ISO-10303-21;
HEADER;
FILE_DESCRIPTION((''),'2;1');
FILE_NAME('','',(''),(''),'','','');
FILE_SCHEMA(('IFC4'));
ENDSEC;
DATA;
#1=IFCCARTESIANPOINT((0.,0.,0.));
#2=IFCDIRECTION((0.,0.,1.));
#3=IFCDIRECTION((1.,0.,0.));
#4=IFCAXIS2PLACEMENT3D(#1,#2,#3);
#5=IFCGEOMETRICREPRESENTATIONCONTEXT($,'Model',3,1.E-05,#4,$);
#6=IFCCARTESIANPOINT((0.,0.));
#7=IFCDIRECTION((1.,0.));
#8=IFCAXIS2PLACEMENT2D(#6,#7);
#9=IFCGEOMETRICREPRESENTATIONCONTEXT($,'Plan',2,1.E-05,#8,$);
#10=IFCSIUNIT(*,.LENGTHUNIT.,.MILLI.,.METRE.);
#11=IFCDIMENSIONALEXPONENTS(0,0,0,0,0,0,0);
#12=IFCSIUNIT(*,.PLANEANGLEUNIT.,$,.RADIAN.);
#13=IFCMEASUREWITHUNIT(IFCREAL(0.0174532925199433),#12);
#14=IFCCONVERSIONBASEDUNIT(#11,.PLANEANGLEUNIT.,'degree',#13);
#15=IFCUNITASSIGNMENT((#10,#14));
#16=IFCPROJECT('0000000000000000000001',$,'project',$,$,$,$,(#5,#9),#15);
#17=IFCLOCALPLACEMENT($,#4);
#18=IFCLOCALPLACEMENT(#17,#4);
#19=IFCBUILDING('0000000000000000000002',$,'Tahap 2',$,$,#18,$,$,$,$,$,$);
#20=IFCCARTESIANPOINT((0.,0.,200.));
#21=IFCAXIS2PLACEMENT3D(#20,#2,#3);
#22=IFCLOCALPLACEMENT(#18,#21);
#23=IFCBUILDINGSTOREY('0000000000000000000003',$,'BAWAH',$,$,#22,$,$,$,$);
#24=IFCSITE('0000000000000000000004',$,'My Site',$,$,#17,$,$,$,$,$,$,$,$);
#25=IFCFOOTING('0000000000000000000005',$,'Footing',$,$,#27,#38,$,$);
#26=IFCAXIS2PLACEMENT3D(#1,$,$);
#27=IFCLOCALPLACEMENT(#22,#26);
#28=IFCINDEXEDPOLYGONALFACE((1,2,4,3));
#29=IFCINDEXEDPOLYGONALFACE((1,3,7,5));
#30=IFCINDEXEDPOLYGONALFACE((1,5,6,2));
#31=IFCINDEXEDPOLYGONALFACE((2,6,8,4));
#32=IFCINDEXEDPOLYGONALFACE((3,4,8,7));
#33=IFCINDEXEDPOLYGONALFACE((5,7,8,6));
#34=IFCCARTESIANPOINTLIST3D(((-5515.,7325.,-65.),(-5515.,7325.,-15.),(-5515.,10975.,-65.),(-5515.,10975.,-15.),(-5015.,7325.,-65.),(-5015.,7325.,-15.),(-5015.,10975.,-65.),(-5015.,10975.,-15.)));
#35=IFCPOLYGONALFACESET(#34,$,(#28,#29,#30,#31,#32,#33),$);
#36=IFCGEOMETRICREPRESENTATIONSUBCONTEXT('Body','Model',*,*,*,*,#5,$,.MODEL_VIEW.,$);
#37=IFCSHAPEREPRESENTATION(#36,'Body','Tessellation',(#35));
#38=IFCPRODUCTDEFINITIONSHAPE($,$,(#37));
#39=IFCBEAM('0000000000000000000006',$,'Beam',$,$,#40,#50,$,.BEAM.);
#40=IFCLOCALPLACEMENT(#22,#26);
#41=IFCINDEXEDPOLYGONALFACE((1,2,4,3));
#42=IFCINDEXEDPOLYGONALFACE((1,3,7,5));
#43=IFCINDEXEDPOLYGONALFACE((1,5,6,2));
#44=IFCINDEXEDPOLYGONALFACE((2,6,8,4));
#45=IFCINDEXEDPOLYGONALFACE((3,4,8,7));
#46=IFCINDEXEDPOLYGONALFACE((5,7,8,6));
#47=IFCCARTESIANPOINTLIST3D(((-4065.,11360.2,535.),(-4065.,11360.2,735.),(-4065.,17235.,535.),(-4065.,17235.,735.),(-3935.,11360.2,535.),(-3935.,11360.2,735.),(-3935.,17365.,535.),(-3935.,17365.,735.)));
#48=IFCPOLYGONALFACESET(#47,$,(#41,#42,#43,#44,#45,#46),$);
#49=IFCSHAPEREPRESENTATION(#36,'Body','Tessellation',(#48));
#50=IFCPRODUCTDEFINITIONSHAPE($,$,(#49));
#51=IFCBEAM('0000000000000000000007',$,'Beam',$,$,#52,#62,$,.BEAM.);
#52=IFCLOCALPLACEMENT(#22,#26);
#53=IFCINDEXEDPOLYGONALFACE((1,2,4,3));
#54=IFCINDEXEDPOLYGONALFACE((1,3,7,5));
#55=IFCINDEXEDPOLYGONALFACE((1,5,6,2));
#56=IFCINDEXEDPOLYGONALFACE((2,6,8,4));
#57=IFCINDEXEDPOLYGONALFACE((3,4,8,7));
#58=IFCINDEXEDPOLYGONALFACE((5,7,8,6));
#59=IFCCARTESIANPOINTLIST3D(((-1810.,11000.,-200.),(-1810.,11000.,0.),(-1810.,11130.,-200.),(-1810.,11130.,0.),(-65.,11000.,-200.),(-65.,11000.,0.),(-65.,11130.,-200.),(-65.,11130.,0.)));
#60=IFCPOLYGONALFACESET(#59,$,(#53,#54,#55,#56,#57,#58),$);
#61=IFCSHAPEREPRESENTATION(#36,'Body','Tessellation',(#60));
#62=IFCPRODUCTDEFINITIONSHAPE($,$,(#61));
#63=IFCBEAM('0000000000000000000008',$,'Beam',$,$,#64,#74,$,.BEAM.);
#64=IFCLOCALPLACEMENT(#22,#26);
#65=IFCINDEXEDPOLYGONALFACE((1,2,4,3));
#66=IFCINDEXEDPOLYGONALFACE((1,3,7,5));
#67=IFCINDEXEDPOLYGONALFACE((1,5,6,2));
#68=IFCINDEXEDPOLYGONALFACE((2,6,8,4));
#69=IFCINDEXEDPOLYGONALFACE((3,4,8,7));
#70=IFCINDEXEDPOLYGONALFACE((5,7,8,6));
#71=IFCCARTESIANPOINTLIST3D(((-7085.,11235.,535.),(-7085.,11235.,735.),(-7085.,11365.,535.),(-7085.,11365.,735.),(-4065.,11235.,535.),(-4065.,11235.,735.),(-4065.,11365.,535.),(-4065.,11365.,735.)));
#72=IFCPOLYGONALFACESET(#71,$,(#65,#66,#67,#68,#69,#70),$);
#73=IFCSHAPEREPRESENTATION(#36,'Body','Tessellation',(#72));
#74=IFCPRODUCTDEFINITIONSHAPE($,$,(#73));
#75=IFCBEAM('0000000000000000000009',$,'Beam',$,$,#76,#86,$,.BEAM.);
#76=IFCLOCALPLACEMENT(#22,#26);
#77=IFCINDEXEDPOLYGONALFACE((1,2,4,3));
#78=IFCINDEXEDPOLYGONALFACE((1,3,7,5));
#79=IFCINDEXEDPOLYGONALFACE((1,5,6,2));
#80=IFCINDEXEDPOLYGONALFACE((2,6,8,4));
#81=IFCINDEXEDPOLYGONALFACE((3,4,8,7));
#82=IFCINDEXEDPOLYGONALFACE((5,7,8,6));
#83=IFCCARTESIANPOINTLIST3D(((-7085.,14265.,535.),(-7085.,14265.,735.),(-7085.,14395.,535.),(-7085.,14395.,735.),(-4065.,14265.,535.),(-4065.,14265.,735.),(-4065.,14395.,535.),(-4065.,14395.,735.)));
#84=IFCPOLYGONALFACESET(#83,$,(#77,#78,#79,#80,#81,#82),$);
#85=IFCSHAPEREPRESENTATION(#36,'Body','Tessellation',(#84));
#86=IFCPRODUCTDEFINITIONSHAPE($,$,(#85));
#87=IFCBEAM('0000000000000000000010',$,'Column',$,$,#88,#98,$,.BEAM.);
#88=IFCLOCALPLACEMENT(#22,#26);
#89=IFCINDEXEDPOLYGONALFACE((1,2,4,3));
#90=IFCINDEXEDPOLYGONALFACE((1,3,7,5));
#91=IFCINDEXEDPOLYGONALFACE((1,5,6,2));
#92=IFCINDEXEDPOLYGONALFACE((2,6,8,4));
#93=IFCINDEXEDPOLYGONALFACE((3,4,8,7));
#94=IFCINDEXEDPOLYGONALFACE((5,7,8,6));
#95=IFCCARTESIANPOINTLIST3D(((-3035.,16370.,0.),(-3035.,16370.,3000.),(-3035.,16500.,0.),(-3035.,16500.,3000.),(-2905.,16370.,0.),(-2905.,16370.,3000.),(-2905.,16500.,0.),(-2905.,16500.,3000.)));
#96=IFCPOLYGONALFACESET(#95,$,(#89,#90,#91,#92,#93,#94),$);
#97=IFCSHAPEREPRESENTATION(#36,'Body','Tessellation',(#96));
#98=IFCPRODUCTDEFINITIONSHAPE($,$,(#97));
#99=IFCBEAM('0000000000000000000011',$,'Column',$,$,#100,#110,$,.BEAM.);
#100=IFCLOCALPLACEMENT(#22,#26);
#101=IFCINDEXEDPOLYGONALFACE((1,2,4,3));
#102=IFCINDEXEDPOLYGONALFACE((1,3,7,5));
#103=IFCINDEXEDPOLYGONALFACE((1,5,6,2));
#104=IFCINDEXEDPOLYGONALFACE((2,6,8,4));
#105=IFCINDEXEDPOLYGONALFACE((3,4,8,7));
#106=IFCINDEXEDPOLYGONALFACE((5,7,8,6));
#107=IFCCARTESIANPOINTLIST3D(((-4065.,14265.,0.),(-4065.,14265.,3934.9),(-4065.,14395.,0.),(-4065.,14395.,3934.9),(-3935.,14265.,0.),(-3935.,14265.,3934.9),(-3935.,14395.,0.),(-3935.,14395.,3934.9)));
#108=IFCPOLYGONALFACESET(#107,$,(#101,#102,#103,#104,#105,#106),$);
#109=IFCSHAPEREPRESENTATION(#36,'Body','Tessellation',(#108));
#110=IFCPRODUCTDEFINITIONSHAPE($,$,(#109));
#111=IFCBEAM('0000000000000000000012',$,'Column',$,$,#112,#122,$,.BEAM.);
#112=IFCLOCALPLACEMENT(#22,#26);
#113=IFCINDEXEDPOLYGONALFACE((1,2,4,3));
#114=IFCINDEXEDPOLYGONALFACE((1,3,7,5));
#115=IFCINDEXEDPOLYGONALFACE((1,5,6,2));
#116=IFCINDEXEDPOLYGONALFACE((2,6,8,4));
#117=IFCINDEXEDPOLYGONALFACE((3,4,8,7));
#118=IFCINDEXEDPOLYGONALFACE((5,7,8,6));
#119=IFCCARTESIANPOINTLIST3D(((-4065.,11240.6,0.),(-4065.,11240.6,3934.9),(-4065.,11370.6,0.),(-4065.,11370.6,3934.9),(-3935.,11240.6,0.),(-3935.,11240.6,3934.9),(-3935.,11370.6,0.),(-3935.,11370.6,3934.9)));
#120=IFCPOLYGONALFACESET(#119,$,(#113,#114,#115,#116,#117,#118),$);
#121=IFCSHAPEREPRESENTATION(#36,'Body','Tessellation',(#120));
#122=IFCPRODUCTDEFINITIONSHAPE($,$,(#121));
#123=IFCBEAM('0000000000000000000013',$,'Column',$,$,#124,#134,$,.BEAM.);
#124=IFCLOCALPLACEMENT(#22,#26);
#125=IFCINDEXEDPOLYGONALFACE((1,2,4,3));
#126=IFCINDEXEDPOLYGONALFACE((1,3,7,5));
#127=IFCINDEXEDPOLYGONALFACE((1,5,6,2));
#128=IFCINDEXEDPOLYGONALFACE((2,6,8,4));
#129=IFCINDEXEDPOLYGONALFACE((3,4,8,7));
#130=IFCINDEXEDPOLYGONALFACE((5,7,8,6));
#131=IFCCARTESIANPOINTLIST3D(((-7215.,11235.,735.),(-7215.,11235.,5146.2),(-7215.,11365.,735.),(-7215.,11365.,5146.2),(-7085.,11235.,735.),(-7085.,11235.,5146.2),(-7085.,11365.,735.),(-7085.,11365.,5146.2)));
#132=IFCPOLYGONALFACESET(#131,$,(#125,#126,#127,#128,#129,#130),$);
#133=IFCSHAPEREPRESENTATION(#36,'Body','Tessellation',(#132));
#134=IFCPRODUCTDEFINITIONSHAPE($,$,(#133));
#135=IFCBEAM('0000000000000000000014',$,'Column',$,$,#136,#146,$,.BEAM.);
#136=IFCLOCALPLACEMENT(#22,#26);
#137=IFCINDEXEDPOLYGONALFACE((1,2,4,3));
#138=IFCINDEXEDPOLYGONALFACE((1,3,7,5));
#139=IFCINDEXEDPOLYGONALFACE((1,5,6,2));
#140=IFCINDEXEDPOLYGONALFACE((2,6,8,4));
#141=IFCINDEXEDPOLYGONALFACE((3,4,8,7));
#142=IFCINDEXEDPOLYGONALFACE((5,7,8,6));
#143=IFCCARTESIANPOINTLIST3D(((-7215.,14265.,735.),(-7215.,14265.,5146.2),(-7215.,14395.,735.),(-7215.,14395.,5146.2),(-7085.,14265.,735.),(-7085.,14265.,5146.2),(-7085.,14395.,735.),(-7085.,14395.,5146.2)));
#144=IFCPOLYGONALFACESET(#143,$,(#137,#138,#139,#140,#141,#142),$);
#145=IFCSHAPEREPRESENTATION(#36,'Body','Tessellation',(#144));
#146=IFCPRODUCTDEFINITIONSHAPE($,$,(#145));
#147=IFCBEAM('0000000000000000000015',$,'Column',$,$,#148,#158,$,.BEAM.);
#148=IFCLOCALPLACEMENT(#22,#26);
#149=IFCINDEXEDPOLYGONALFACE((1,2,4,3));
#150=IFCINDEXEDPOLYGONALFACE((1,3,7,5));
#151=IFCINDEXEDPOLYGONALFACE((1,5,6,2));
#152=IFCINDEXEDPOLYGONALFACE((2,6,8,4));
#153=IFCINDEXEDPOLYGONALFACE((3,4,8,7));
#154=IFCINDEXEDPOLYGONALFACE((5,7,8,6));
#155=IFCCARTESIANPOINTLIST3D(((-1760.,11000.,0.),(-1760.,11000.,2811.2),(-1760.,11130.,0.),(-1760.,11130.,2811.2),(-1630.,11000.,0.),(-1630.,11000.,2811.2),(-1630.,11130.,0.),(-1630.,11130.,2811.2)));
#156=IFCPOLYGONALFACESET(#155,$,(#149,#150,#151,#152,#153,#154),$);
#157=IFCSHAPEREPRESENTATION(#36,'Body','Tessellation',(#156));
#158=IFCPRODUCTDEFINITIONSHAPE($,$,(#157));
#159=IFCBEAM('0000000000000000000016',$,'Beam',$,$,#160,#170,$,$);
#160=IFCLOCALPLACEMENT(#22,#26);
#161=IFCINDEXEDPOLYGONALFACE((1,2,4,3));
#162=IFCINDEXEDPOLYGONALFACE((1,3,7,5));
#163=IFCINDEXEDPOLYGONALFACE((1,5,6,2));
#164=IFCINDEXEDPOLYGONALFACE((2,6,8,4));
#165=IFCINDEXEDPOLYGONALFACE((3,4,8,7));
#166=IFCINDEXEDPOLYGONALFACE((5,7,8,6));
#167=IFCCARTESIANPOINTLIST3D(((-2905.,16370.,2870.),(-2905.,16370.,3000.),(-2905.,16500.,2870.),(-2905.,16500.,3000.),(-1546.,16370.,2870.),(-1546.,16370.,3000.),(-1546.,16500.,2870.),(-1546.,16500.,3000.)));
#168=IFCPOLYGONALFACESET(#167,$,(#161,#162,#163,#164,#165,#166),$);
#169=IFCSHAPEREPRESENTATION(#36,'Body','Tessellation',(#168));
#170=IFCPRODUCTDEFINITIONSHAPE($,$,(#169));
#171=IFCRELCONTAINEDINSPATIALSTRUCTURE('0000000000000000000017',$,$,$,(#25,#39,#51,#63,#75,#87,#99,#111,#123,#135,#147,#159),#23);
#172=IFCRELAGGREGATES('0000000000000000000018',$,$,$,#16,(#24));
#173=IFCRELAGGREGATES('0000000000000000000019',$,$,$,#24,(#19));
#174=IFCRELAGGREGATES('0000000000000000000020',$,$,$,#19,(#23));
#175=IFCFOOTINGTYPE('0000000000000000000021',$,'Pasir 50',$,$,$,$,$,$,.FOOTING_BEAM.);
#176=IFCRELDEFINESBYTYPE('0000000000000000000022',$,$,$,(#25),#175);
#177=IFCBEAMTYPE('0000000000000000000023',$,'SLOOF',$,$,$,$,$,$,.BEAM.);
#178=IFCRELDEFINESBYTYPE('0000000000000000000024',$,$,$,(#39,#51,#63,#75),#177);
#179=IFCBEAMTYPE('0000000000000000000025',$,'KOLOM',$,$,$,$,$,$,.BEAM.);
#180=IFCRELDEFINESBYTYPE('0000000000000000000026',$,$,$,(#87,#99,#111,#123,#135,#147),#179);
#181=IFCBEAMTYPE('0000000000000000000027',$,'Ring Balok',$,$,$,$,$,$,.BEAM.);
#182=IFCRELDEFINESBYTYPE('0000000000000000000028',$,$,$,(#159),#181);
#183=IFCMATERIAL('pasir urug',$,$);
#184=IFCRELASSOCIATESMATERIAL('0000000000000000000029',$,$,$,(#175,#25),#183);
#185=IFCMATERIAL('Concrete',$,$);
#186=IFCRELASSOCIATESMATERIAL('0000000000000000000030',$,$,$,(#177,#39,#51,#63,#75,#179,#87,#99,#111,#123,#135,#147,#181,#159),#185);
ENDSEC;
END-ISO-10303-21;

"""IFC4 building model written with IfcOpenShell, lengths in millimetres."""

from ifc_helpers import new_model, entity, si_unit, converted_unit, frame, origin_with_axes, origin_2d_with_axis, place, context, subcontext, project, spatial, indexed_curve, rectangle, outline, extrude, clip, halfspace, material, material_profile, profile_set, profile_usage, type_object, element, save


model = new_model("IFC4")

# Units and contexts
model_context = context("Model", 3, precision=1e-05, world=origin_with_axes())
plan_context = context("Plan", 2, precision=1e-05, world=origin_2d_with_axis())
body_context = subcontext(model_context, "Body", "Model", "MODEL_VIEW")
ifc_project = project(units=[si_unit("LENGTHUNIT", "METRE", prefix="MILLI"), converted_unit("PLANEANGLEUNIT", "degree", entity("IfcReal", 0.0174532925199433), si_unit("PLANEANGLEUNIT", "RADIAN"), dimensions=[0, 0, 0, 0, 0, 0, 0])], contexts=[model_context, plan_context])

# Site, building, storey
site_placement = place(None, origin_with_axes())
site = spatial("IfcSite", under=ifc_project, at=site_placement, Name="My Site")
building_placement = place(site_placement, origin_with_axes())
building = spatial("IfcBuilding", under=site, at=building_placement, Name="Tahap 2")
storey_placement = place(building_placement, frame((0.0, 0.0, 200.0), z_axis=(0.0, 0.0, 1.0), x_axis=(1.0, 0.0, 0.0)))
storey = spatial("IfcBuildingStorey", under=building, at=storey_placement, Name="BAWAH")

# Footing
ifc_material_1 = material(Name="pasir urug")
ifc_material_profile_1 = material_profile(ifc_material_1, rectangle(XDim=500.0, YDim=50.0, kind="CURVE"))
ifc_profile_set_1 = profile_set([ifc_material_profile_1])
ifc_profile_usage_1 = profile_usage(ifc_profile_set_1, cardinal=9)
footing_type = type_object("IfcFootingType", Name="Pasir 50", PredefinedType="FOOTING_BEAM", material=ifc_profile_set_1)
footing_placement = place(storey_placement, frame((-5515.0, 10975.0, -15.0), z_axis=(0.0, -1.0, 0.0), x_axis=(1.0, 0.0, 0.0)))
element("IfcFooting", 1, at=footing_placement, inside=storey, type_object=footing_type, material=ifc_profile_usage_1, Name="Footing", context=body_context, shape_type="SweptSolid", body=[
    extrude(rectangle(XDim=500.0, YDim=50.0, kind="CURVE"), frame((250.0, -25.0, 0.0), z_axis=(0.0, 0.0, 1.0), x_axis=(1.0, 0.0, 0.0)), (0.0, 0.0, 1.0), 3650.0),
])

# Beams
ifc_material_2 = material(Name="Concrete")
ifc_material_profile_2 = material_profile(ifc_material_2, outline(indexed_curve([(-65.0, 100.0), (65.0, 100.0), (65.0, -100.0), (-65.0, -100.0), (-65.0, 100.0)])))
ifc_profile_set_2 = profile_set([ifc_material_profile_2])
ifc_profile_usage_2 = profile_usage(ifc_profile_set_2, cardinal=3)
beam_type_1 = type_object("IfcBeamType", Name="SLOOF", PredefinedType="BEAM", material=ifc_profile_set_2)
beam_1_placement = place(storey_placement, frame((-3935.0, 11360.2, 535.0), z_axis=(0.0, 1.0, 0.0), x_axis=(-1.0, 0.0, 0.0)))
element("IfcBeam", 2, at=beam_1_placement, inside=storey, type_object=beam_type_1, material=ifc_profile_usage_2, Name="Beam", PredefinedType="BEAM", context=body_context, shape_type="Clipping", body=[
    clip(extrude(outline(indexed_curve([(-65.0, 100.0), (65.0, 100.0), (65.0, -100.0), (-65.0, -100.0), (-65.0, 100.0)])), frame((65.0, 100.0, 0.0), z_axis=(0.0, 0.0, 1.0), x_axis=(1.0, 0.0, 0.0)), (0.0, 0.0, 1.0), 6004.8), halfspace(frame((0.0, -735.0, 6004.8), z_axis=(0.707111, 0.0, 0.707103), x_axis=(0.0, -1.0, 0.0)), False)),
])
ifc_profile_usage_3 = profile_usage(ifc_profile_set_2, cardinal=2)
beam_2_placement = place(storey_placement, frame((-1810.0, 11065.0, -200.0), z_axis=(1.0, 0.0, 0.0), x_axis=(0.0, 1.0, 0.0)))
element("IfcBeam", 3, at=beam_2_placement, inside=storey, type_object=beam_type_1, material=ifc_profile_usage_3, Name="Beam", PredefinedType="BEAM", context=body_context, shape_type="SweptSolid", body=[
    extrude(outline(indexed_curve([(-65.0, 100.0), (65.0, 100.0), (65.0, -100.0), (-65.0, -100.0), (-65.0, 100.0)])), frame((0.0, 100.0, 0.0), z_axis=(0.0, 0.0, 1.0), x_axis=(1.0, 0.0, 0.0)), (0.0, 0.0, 1.0), 1745.0),
])
ifc_profile_usage_4 = profile_usage(ifc_profile_set_2, cardinal=2)
beam_3_placement = place(storey_placement, frame((-7085.0, 11300.0, 535.0), z_axis=(1.0, 0.0, 0.0), x_axis=(0.0, 1.0, 0.0)))
element("IfcBeam", 4, at=beam_3_placement, inside=storey, type_object=beam_type_1, material=ifc_profile_usage_4, Name="Beam", PredefinedType="BEAM", context=body_context, shape_type="SweptSolid", body=[
    extrude(outline(indexed_curve([(-65.0, 100.0), (65.0, 100.0), (65.0, -100.0), (-65.0, -100.0), (-65.0, 100.0)])), frame((0.0, 100.0, 0.0), z_axis=(0.0, 0.0, 1.0), x_axis=(1.0, 0.0, 0.0)), (0.0, 0.0, 1.0), 3020.0),
])
ifc_profile_usage_5 = profile_usage(ifc_profile_set_2, cardinal=2)
beam_4_placement = place(storey_placement, frame((-7085.0, 14330.0, 535.0), z_axis=(1.0, 0.0, 0.0), x_axis=(0.0, 1.0, 0.0)))
element("IfcBeam", 5, at=beam_4_placement, inside=storey, type_object=beam_type_1, material=ifc_profile_usage_5, Name="Beam", PredefinedType="BEAM", context=body_context, shape_type="SweptSolid", body=[
    extrude(outline(indexed_curve([(-65.0, 100.0), (65.0, 100.0), (65.0, -100.0), (-65.0, -100.0), (-65.0, 100.0)])), frame((0.0, 100.0, 0.0), z_axis=(0.0, 0.0, 1.0), x_axis=(1.0, 0.0, 0.0)), (0.0, 0.0, 1.0), 3020.0),
])
ifc_material_profile_3 = material_profile(ifc_material_2, rectangle(XDim=130.0, YDim=130.0, kind="CURVE"))
ifc_profile_set_3 = profile_set([ifc_material_profile_3])
ifc_profile_usage_6 = profile_usage(ifc_profile_set_3, cardinal=2)
beam_type_2 = type_object("IfcBeamType", Name="KOLOM", PredefinedType="BEAM", material=ifc_profile_set_3)
beam_5_placement = place(storey_placement, frame((-2970.0, 16370.0, 0.0), z_axis=(0.0, 0.0, 1.0), x_axis=(1.0, 0.0, 0.0)))
element("IfcBeam", 6, at=beam_5_placement, inside=storey, type_object=beam_type_2, material=ifc_profile_usage_6, Name="Column", PredefinedType="BEAM", context=body_context, shape_type="SweptSolid", body=[
    extrude(rectangle(XDim=130.0, YDim=130.0, kind="CURVE"), frame((0.0, 65.0, 0.0), z_axis=(0.0, 0.0, 1.0), x_axis=(1.0, 0.0, 0.0)), (0.0, 0.0, 1.0), 3000.0),
])
ifc_profile_usage_7 = profile_usage(ifc_profile_set_3, cardinal=5)
beam_6_placement = place(storey_placement, frame((-4000.0, 14330.0, 0.0), z_axis=(0.0, 0.0, 1.0), x_axis=(1.0, 0.0, 0.0)))
element("IfcBeam", 7, at=beam_6_placement, inside=storey, type_object=beam_type_2, material=ifc_profile_usage_7, Name="Column", PredefinedType="BEAM", context=body_context, shape_type="SweptSolid", body=[
    extrude(rectangle(XDim=130.0, YDim=130.0, kind="CURVE"), origin_with_axes(), (0.0, 0.0, 1.0), 3934.9),
])
ifc_profile_usage_8 = profile_usage(ifc_profile_set_3, cardinal=5)
beam_7_placement = place(storey_placement, frame((-4000.0, 11305.6, 0.0), z_axis=(0.0, 0.0, 1.0), x_axis=(1.0, 0.0, 0.0)))
element("IfcBeam", 8, at=beam_7_placement, inside=storey, type_object=beam_type_2, material=ifc_profile_usage_8, Name="Column", PredefinedType="BEAM", context=body_context, shape_type="SweptSolid", body=[
    extrude(rectangle(XDim=130.0, YDim=130.0, kind="CURVE"), origin_with_axes(), (0.0, 0.0, 1.0), 3934.9),
])
ifc_profile_usage_9 = profile_usage(ifc_profile_set_3, cardinal=5)
beam_8_placement = place(storey_placement, frame((-7150.0, 11300.0, 735.0), z_axis=(0.0, 0.0, 1.0), x_axis=(1.0, 0.0, 0.0)))
element("IfcBeam", 9, at=beam_8_placement, inside=storey, type_object=beam_type_2, material=ifc_profile_usage_9, Name="Column", PredefinedType="BEAM", context=body_context, shape_type="SweptSolid", body=[
    extrude(rectangle(XDim=130.0, YDim=130.0, kind="CURVE"), origin_with_axes(), (0.0, 0.0, 1.0), 4411.2),
])
ifc_profile_usage_10 = profile_usage(ifc_profile_set_3, cardinal=5)
beam_9_placement = place(storey_placement, frame((-7150.0, 14330.0, 735.0), z_axis=(0.0, 0.0, 1.0), x_axis=(1.0, 0.0, 0.0)))
element("IfcBeam", 10, at=beam_9_placement, inside=storey, type_object=beam_type_2, material=ifc_profile_usage_10, Name="Column", PredefinedType="BEAM", context=body_context, shape_type="SweptSolid", body=[
    extrude(rectangle(XDim=130.0, YDim=130.0, kind="CURVE"), origin_with_axes(), (0.0, 0.0, 1.0), 4411.2),
])
ifc_profile_usage_11 = profile_usage(ifc_profile_set_3, cardinal=5)
beam_10_placement = place(storey_placement, frame((-1695.0, 11065.0, 0.0), z_axis=(0.0, 0.0, 1.0), x_axis=(1.0, 0.0, 0.0)))
element("IfcBeam", 11, at=beam_10_placement, inside=storey, type_object=beam_type_2, material=ifc_profile_usage_11, Name="Column", PredefinedType="BEAM", context=body_context, shape_type="SweptSolid", body=[
    extrude(rectangle(XDim=130.0, YDim=130.0, kind="CURVE"), origin_with_axes(), (0.0, 0.0, 1.0), 2811.2),
])
ifc_material_profile_4 = material_profile(ifc_material_2, rectangle(XDim=130.0, YDim=130.0))
ifc_profile_set_4 = profile_set([ifc_material_profile_4])
ifc_profile_usage_12 = profile_usage(ifc_profile_set_4, cardinal=9)
beam_type_3 = type_object("IfcBeamType", Name="Ring Balok", PredefinedType="BEAM", material=ifc_profile_set_4)
beam_11_placement = place(storey_placement, frame((-2905.0, 16370.0, 3000.0), z_axis=(1.0, 0.0, 0.000001), x_axis=(0.0, 1.0, 0.0)))
element("IfcBeam", 12, at=beam_11_placement, inside=storey, type_object=beam_type_3, material=ifc_profile_usage_12, Name="Beam", context=body_context, shape_type="SweptSolid", body=[
    extrude(rectangle(XDim=130.0, YDim=130.0), frame((65.0, -65.0, 0.0), z_axis=(0.0, 0.0, 1.0), x_axis=(1.0, 0.0, 0.0)), (0.0, 0.0, 1.0), 1359.0),
])

save(model, "model.ifc")
